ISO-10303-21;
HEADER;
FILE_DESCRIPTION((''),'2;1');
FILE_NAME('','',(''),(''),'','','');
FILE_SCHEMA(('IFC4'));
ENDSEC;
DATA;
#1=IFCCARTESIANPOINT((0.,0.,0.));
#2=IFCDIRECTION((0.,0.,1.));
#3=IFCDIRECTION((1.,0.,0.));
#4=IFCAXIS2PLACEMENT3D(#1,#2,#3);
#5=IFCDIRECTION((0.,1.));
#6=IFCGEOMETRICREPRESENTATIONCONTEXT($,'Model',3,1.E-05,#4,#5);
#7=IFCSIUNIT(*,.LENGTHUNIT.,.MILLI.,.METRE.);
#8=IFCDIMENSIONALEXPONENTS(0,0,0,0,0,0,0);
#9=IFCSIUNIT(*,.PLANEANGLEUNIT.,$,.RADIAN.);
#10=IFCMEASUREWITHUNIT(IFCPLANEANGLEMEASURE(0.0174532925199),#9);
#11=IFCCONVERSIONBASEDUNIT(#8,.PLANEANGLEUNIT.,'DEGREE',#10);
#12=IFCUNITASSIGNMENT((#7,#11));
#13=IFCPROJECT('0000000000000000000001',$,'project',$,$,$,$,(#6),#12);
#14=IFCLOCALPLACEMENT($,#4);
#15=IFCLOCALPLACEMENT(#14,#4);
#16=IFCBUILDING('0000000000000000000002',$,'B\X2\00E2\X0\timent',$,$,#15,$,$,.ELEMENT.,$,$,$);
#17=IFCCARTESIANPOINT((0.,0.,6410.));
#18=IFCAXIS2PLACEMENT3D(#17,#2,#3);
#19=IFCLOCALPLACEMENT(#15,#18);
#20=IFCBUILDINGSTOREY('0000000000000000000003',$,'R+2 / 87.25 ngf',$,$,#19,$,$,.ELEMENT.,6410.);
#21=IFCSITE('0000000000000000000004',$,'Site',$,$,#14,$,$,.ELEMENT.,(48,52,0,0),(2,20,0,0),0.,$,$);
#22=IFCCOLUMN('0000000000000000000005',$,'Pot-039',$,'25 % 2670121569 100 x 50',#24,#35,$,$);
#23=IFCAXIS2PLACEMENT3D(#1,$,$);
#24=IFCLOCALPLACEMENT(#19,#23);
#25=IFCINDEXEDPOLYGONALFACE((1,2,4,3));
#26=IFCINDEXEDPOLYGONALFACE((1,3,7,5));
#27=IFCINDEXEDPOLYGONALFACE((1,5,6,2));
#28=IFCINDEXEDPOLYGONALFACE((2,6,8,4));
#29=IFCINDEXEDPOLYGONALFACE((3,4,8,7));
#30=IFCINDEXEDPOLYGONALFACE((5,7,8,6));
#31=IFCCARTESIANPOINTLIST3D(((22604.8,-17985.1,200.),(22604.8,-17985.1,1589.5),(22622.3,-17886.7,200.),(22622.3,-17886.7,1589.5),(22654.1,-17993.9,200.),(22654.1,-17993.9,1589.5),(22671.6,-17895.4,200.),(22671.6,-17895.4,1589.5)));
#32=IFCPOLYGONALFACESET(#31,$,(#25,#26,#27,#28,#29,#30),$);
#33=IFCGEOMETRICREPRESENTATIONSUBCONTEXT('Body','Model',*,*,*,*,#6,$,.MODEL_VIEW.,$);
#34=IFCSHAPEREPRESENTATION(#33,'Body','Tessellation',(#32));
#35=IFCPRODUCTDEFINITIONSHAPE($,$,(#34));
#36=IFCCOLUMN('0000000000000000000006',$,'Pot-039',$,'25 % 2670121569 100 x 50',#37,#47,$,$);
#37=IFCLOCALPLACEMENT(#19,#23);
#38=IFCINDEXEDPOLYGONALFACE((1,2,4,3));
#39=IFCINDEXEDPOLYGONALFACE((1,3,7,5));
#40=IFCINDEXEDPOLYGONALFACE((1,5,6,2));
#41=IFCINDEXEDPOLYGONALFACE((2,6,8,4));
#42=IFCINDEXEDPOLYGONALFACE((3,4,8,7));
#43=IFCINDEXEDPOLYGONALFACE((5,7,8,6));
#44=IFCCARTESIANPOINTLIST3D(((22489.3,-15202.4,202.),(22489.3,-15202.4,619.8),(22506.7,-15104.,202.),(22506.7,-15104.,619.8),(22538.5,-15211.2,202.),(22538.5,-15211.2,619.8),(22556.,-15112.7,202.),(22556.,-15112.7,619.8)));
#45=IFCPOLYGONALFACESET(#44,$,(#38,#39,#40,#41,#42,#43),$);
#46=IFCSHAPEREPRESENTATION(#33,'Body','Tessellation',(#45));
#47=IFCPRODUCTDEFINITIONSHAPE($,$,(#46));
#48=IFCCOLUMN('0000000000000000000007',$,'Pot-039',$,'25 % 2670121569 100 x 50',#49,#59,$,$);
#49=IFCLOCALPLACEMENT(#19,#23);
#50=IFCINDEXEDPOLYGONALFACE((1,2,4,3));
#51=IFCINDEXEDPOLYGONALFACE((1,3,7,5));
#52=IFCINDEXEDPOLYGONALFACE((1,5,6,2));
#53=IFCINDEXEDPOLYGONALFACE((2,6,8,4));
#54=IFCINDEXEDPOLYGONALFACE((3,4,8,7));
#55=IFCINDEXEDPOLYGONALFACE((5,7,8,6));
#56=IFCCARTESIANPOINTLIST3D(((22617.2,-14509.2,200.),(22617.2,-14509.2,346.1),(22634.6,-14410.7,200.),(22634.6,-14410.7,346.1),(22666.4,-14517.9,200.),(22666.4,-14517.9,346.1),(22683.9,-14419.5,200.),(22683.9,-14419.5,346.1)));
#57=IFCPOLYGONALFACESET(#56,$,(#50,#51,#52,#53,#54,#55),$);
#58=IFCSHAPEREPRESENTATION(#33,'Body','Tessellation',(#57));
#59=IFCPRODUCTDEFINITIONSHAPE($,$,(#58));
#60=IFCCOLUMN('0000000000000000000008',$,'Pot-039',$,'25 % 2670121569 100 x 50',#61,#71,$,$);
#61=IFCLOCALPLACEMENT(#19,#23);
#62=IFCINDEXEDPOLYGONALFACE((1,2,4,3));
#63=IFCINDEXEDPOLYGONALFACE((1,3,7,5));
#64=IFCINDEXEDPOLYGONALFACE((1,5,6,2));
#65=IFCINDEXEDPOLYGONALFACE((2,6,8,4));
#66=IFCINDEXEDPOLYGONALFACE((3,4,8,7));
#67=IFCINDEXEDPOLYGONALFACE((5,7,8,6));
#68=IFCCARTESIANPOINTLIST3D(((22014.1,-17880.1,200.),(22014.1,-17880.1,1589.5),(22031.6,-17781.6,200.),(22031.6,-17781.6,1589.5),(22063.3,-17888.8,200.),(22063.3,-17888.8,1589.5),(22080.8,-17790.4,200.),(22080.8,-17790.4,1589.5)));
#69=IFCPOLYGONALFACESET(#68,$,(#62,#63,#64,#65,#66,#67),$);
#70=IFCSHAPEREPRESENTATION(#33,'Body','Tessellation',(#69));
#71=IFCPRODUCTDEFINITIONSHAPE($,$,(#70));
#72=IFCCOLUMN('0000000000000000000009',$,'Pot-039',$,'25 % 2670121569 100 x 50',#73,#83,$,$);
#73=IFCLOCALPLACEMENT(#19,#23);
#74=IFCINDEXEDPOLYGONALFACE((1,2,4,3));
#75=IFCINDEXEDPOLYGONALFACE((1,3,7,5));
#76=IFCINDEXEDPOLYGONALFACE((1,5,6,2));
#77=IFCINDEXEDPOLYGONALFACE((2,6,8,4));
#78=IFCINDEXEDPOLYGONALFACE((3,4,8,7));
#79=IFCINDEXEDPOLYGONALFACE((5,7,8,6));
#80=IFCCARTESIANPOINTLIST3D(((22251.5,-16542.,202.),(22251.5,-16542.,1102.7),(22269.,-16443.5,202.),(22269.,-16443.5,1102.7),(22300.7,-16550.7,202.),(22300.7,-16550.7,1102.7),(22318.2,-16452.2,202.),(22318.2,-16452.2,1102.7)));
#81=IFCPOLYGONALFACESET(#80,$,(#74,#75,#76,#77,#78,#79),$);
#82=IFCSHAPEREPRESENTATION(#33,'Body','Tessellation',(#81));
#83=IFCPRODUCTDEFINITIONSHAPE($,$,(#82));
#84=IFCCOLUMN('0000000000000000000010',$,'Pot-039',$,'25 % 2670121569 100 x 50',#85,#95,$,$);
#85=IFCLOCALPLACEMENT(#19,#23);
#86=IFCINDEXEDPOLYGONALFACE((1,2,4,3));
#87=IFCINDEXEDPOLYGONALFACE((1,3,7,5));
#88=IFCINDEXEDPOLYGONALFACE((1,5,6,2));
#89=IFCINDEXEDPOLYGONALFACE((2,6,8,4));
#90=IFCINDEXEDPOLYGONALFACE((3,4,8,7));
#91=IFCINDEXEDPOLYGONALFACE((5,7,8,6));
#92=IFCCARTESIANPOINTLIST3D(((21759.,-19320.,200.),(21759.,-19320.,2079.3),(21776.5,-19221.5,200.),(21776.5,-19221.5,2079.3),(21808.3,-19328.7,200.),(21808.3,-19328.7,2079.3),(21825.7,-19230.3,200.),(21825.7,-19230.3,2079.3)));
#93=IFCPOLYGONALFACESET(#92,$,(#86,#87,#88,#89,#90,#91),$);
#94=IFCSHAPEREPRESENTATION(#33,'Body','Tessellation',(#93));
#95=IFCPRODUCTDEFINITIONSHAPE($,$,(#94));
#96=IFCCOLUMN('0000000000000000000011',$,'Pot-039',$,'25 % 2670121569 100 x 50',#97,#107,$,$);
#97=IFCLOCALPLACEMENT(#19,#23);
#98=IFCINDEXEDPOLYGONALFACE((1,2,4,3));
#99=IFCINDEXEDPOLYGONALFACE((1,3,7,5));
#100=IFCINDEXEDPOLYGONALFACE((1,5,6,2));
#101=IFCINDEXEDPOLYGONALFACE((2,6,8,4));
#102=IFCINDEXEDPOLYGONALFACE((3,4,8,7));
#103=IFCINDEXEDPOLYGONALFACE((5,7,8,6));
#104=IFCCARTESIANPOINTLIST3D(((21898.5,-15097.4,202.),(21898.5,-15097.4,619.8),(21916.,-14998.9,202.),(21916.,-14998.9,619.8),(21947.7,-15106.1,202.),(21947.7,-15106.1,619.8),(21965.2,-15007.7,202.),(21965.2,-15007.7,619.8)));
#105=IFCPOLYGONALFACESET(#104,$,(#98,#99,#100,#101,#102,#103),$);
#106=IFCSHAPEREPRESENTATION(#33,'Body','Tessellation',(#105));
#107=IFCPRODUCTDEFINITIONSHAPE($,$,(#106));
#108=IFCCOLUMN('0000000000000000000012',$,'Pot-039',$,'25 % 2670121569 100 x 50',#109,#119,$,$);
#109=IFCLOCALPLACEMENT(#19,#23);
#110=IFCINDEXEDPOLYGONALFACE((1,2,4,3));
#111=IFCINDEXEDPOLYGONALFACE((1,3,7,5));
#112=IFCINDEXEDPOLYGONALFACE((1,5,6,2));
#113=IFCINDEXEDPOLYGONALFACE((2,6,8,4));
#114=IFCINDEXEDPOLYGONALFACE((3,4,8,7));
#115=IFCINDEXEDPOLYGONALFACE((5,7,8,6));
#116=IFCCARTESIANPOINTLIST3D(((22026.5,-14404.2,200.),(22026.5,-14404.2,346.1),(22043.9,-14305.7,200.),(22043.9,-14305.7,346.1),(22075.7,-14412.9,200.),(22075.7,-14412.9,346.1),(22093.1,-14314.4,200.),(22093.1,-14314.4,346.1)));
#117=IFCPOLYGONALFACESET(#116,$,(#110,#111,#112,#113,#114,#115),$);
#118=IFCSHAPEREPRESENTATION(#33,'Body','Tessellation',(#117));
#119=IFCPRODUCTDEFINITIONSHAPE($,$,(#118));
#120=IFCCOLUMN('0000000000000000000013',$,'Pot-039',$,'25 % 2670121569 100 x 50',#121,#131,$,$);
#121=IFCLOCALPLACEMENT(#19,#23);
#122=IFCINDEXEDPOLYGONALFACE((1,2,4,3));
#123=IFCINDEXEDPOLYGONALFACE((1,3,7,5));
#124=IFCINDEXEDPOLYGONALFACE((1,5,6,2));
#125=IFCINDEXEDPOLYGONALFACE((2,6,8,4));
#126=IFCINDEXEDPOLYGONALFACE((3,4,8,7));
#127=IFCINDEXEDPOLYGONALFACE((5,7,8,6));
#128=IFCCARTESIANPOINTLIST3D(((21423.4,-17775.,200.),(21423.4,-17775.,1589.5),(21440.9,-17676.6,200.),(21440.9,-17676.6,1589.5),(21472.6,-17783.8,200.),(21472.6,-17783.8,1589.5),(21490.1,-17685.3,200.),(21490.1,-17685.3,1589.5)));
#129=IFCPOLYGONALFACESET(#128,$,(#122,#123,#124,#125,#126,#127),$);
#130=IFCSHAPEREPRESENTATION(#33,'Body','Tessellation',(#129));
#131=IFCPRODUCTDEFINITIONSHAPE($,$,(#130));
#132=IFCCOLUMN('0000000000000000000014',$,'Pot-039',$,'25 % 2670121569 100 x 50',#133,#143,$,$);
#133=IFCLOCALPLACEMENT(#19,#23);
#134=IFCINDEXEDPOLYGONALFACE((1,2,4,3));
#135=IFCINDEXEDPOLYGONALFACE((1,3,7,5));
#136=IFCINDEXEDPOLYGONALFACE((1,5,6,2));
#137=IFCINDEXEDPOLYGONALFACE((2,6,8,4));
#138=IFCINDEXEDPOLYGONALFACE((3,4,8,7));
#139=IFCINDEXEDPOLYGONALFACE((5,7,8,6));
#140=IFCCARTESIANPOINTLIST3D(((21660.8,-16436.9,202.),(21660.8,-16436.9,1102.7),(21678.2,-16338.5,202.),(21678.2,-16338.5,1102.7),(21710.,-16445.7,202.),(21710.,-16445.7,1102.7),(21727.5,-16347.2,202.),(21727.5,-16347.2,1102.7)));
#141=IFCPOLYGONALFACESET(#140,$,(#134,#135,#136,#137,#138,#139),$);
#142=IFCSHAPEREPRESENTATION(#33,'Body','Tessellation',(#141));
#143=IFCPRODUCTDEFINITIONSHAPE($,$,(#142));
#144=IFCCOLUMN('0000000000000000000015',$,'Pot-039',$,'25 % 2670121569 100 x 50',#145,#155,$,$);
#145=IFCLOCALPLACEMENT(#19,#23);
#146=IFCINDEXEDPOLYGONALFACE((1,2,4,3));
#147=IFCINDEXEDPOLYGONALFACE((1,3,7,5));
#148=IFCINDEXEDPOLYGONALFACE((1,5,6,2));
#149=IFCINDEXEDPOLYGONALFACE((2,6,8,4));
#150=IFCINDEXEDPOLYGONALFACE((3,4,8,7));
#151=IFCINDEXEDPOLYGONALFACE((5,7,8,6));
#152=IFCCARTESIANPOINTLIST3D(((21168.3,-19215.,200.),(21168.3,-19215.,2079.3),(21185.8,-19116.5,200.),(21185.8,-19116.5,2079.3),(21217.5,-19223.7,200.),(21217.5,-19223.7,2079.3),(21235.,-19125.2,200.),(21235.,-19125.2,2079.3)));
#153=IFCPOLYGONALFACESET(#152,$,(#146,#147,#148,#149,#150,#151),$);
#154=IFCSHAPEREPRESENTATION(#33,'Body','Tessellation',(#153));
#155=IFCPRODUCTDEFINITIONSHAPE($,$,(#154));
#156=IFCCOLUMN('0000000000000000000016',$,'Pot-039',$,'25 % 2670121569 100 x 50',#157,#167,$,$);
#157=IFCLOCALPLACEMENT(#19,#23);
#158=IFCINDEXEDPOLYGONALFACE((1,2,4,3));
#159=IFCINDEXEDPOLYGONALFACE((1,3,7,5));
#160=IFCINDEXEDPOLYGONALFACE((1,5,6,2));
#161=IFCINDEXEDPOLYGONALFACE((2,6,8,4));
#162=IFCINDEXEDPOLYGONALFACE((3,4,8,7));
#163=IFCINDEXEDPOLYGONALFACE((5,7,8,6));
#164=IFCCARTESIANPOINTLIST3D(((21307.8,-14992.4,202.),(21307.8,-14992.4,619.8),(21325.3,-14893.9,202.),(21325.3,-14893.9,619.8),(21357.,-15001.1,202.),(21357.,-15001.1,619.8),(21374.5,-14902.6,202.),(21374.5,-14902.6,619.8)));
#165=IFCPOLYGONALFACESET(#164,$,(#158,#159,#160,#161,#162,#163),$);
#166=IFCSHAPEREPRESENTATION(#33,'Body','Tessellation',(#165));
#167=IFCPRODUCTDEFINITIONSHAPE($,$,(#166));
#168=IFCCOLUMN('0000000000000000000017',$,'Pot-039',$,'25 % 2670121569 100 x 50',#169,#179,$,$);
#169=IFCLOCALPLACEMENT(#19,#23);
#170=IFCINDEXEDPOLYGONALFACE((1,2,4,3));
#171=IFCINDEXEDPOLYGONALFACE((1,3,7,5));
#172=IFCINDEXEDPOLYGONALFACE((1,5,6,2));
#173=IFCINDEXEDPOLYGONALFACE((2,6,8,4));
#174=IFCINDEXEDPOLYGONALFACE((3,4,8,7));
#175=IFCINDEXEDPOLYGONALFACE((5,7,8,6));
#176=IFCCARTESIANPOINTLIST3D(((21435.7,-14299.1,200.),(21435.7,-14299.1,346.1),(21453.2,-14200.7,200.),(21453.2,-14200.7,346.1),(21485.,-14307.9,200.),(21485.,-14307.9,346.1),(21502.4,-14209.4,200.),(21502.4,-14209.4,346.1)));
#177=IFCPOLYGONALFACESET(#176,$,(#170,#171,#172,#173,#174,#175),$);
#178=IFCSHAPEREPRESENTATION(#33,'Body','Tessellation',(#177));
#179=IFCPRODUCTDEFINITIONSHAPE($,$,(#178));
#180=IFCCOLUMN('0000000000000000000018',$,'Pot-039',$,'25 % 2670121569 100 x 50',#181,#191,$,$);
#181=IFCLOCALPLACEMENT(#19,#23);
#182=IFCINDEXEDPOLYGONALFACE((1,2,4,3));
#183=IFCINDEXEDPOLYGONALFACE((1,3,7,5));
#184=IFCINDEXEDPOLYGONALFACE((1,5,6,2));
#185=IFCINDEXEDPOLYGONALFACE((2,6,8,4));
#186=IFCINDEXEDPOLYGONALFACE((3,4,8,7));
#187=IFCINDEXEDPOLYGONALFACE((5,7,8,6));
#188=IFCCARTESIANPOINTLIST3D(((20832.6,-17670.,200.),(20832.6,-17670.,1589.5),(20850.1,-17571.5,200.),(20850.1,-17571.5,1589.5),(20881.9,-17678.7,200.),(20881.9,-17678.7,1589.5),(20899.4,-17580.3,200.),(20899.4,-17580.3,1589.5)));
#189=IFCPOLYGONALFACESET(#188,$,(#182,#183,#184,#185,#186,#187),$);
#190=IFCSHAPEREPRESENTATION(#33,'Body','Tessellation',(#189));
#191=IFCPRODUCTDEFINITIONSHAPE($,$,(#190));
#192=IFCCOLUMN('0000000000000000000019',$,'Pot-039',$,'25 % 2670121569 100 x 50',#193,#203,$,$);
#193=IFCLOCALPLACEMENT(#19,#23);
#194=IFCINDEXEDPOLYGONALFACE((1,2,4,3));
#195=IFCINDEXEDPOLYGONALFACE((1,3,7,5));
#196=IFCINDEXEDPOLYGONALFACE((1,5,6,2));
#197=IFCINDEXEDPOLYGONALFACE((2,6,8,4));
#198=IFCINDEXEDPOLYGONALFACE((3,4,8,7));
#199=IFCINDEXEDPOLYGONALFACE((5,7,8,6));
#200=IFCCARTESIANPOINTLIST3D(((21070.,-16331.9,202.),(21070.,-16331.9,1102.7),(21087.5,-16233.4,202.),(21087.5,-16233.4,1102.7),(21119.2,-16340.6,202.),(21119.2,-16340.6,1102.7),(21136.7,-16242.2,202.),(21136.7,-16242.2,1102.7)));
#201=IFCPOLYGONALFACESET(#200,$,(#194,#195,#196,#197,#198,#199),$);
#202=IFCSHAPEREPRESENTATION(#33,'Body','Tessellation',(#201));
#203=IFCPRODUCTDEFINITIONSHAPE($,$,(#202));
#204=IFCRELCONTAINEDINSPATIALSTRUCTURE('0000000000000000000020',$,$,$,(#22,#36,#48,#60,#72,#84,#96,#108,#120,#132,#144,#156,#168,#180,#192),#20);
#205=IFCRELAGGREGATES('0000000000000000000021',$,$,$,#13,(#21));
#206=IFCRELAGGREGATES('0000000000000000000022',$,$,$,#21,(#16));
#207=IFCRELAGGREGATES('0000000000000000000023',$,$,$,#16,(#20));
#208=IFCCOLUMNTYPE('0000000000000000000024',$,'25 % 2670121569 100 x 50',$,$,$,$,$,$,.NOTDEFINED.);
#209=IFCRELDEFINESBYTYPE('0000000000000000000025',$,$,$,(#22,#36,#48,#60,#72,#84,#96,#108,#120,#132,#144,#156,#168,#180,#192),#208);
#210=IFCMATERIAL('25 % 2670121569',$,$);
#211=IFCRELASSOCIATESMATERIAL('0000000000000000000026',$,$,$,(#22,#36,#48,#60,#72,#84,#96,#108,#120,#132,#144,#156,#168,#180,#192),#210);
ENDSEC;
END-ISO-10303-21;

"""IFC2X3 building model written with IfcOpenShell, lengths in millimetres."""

from ifc_helpers import new_model, entity, si_unit, converted_unit, direction, frame, origin_with_axes, origin_2d_with_axis, place, context, subcontext, project, spatial, rectangle, extrude, material, type_object, element, save


model = new_model("IFC2X3")

# Units and contexts
model_context = context("Model", 3, precision=1e-05, world=origin_with_axes(), true_north=direction((0.0, 1.0)))
body_context = subcontext(model_context, "Body", "Model", "MODEL_VIEW")
ifc_project = project(units=[si_unit("LENGTHUNIT", "METRE", prefix="MILLI"), converted_unit("PLANEANGLEUNIT", "DEGREE", entity("IfcPlaneAngleMeasure", 0.0174532925199), si_unit("PLANEANGLEUNIT", "RADIAN"), dimensions=[0, 0, 0, 0, 0, 0, 0])], contexts=[model_context])

# Site, building, storey
site_placement = place(None, origin_with_axes())
site = spatial("IfcSite", under=ifc_project, at=site_placement, Name="Site", CompositionType="ELEMENT", RefLatitude=(48, 52, 0, 0), RefLongitude=(2, 20, 0, 0), RefElevation=0.0)
building_placement = place(site_placement, origin_with_axes())
building = spatial("IfcBuilding", under=site, at=building_placement, Name="Bâtiment", CompositionType="ELEMENT")
storey_placement = place(building_placement, frame((0.0, 0.0, 6410.0), z_axis=(0.0, 0.0, 1.0), x_axis=(1.0, 0.0, 0.0)))
storey = spatial("IfcBuildingStorey", under=building, at=storey_placement, Name="R+2 / 87.25 ngf", CompositionType="ELEMENT", Elevation=6410.0)

# Columns
ifc_material_1 = material(Name="25 % 2670121569")
column_type = type_object("IfcColumnType", Name="25 % 2670121569 100 x 50", PredefinedType="NOTDEFINED")
column_1_placement = place(storey_placement, frame((22638.2, -17940.3, 200.0), z_axis=(0.0, 0.0, 1.0), x_axis=(0.17478, 0.984607, 0.0)))
element("IfcColumn", 1, at=column_1_placement, inside=storey, type_object=column_type, material=ifc_material_1, Name="Pot-039", ObjectType="25 % 2670121569 100 x 50", context=body_context, shape_type="SweptSolid", body=[
    extrude(rectangle(XDim=100.0, YDim=50.0, at=origin_2d_with_axis()), origin_with_axes(), (0.0, 0.0, 1.0), 1389.5),
])
column_2_placement = place(storey_placement, frame((22522.6, -15157.6, 202.0), z_axis=(0.0, 0.0, 1.0), x_axis=(0.17478, 0.984607, 0.0)))
element("IfcColumn", 2, at=column_2_placement, inside=storey, type_object=column_type, material=ifc_material_1, Name="Pot-039", ObjectType="25 % 2670121569 100 x 50", context=body_context, shape_type="SweptSolid", body=[
    extrude(rectangle(XDim=100.0, YDim=50.0, at=origin_2d_with_axis()), origin_with_axes(), (0.0, 0.0, 1.0), 417.8),
])
column_3_placement = place(storey_placement, frame((22650.5, -14464.3, 200.0), z_axis=(0.0, 0.0, 1.0), x_axis=(0.174407, 0.984674, 0.0)))
element("IfcColumn", 3, at=column_3_placement, inside=storey, type_object=column_type, material=ifc_material_1, Name="Pot-039", ObjectType="25 % 2670121569 100 x 50", context=body_context, shape_type="SweptSolid", body=[
    extrude(rectangle(XDim=100.0, YDim=50.0, at=origin_2d_with_axis()), origin_with_axes(), (0.0, 0.0, 1.0), 146.1),
])
column_4_placement = place(storey_placement, frame((22047.5, -17835.2, 200.0), z_axis=(0.0, 0.0, 1.0), x_axis=(0.17478, 0.984607, 0.0)))
element("IfcColumn", 4, at=column_4_placement, inside=storey, type_object=column_type, material=ifc_material_1, Name="Pot-039", ObjectType="25 % 2670121569 100 x 50", context=body_context, shape_type="SweptSolid", body=[
    extrude(rectangle(XDim=100.0, YDim=50.0, at=origin_2d_with_axis()), origin_with_axes(), (0.0, 0.0, 1.0), 1389.5),
])
column_5_placement = place(storey_placement, frame((22284.8, -16497.1, 202.0), z_axis=(0.0, 0.0, 1.0), x_axis=(0.17478, 0.984607, 0.0)))
element("IfcColumn", 5, at=column_5_placement, inside=storey, type_object=column_type, material=ifc_material_1, Name="Pot-039", ObjectType="25 % 2670121569 100 x 50", context=body_context, shape_type="SweptSolid", body=[
    extrude(rectangle(XDim=100.0, YDim=50.0, at=origin_2d_with_axis()), origin_with_axes(), (0.0, 0.0, 1.0), 900.7),
])
column_6_placement = place(storey_placement, frame((21792.4, -19275.1, 200.0), z_axis=(0.0, 0.0, 1.0), x_axis=(0.17478, 0.984607, 0.0)))
element("IfcColumn", 6, at=column_6_placement, inside=storey, type_object=column_type, material=ifc_material_1, Name="Pot-039", ObjectType="25 % 2670121569 100 x 50", context=body_context, shape_type="SweptSolid", body=[
    extrude(rectangle(XDim=100.0, YDim=50.0, at=origin_2d_with_axis()), origin_with_axes(), (0.0, 0.0, 1.0), 1879.3),
])
column_7_placement = place(storey_placement, frame((21931.9, -15052.5, 202.0), z_axis=(0.0, 0.0, 1.0), x_axis=(0.17478, 0.984607, 0.0)))
element("IfcColumn", 7, at=column_7_placement, inside=storey, type_object=column_type, material=ifc_material_1, Name="Pot-039", ObjectType="25 % 2670121569 100 x 50", context=body_context, shape_type="SweptSolid", body=[
    extrude(rectangle(XDim=100.0, YDim=50.0, at=origin_2d_with_axis()), origin_with_axes(), (0.0, 0.0, 1.0), 417.8),
])
column_8_placement = place(storey_placement, frame((22059.8, -14359.3, 200.0), z_axis=(0.0, 0.0, 1.0), x_axis=(0.174407, 0.984674, 0.0)))
element("IfcColumn", 8, at=column_8_placement, inside=storey, type_object=column_type, material=ifc_material_1, Name="Pot-039", ObjectType="25 % 2670121569 100 x 50", context=body_context, shape_type="SweptSolid", body=[
    extrude(rectangle(XDim=100.0, YDim=50.0, at=origin_2d_with_axis()), origin_with_axes(), (0.0, 0.0, 1.0), 146.1),
])
column_9_placement = place(storey_placement, frame((21456.7, -17730.2, 200.0), z_axis=(0.0, 0.0, 1.0), x_axis=(0.17478, 0.984607, 0.0)))
element("IfcColumn", 9, at=column_9_placement, inside=storey, type_object=column_type, material=ifc_material_1, Name="Pot-039", ObjectType="25 % 2670121569 100 x 50", context=body_context, shape_type="SweptSolid", body=[
    extrude(rectangle(XDim=100.0, YDim=50.0, at=origin_2d_with_axis()), origin_with_axes(), (0.0, 0.0, 1.0), 1389.5),
])
column_10_placement = place(storey_placement, frame((21694.1, -16392.1, 202.0), z_axis=(0.0, 0.0, 1.0), x_axis=(0.17478, 0.984607, 0.0)))
element("IfcColumn", 10, at=column_10_placement, inside=storey, type_object=column_type, material=ifc_material_1, Name="Pot-039", ObjectType="25 % 2670121569 100 x 50", context=body_context, shape_type="SweptSolid", body=[
    extrude(rectangle(XDim=100.0, YDim=50.0, at=origin_2d_with_axis()), origin_with_axes(), (0.0, 0.0, 1.0), 900.7),
])
column_11_placement = place(storey_placement, frame((21201.7, -19170.1, 200.0), z_axis=(0.0, 0.0, 1.0), x_axis=(0.17478, 0.984607, 0.0)))
element("IfcColumn", 11, at=column_11_placement, inside=storey, type_object=column_type, material=ifc_material_1, Name="Pot-039", ObjectType="25 % 2670121569 100 x 50", context=body_context, shape_type="SweptSolid", body=[
    extrude(rectangle(XDim=100.0, YDim=50.0, at=origin_2d_with_axis()), origin_with_axes(), (0.0, 0.0, 1.0), 1879.3),
])
column_12_placement = place(storey_placement, frame((21341.1, -14947.5, 202.0), z_axis=(0.0, 0.0, 1.0), x_axis=(0.17478, 0.984607, 0.0)))
element("IfcColumn", 12, at=column_12_placement, inside=storey, type_object=column_type, material=ifc_material_1, Name="Pot-039", ObjectType="25 % 2670121569 100 x 50", context=body_context, shape_type="SweptSolid", body=[
    extrude(rectangle(XDim=100.0, YDim=50.0, at=origin_2d_with_axis()), origin_with_axes(), (0.0, 0.0, 1.0), 417.8),
])
column_13_placement = place(storey_placement, frame((21469.1, -14254.3, 200.0), z_axis=(0.0, 0.0, 1.0), x_axis=(0.174407, 0.984674, 0.0)))
element("IfcColumn", 13, at=column_13_placement, inside=storey, type_object=column_type, material=ifc_material_1, Name="Pot-039", ObjectType="25 % 2670121569 100 x 50", context=body_context, shape_type="SweptSolid", body=[
    extrude(rectangle(XDim=100.0, YDim=50.0, at=origin_2d_with_axis()), origin_with_axes(), (0.0, 0.0, 1.0), 146.1),
])
column_14_placement = place(storey_placement, frame((20866.0, -17625.1, 200.0), z_axis=(0.0, 0.0, 1.0), x_axis=(0.17478, 0.984607, 0.0)))
element("IfcColumn", 14, at=column_14_placement, inside=storey, type_object=column_type, material=ifc_material_1, Name="Pot-039", ObjectType="25 % 2670121569 100 x 50", context=body_context, shape_type="SweptSolid", body=[
    extrude(rectangle(XDim=100.0, YDim=50.0, at=origin_2d_with_axis()), origin_with_axes(), (0.0, 0.0, 1.0), 1389.5),
])
column_15_placement = place(storey_placement, frame((21103.4, -16287.0, 202.0), z_axis=(0.0, 0.0, 1.0), x_axis=(0.17478, 0.984607, 0.0)))
element("IfcColumn", 15, at=column_15_placement, inside=storey, type_object=column_type, material=ifc_material_1, Name="Pot-039", ObjectType="25 % 2670121569 100 x 50", context=body_context, shape_type="SweptSolid", body=[
    extrude(rectangle(XDim=100.0, YDim=50.0, at=origin_2d_with_axis()), origin_with_axes(), (0.0, 0.0, 1.0), 900.7),
])

save(model, "model.ifc")
